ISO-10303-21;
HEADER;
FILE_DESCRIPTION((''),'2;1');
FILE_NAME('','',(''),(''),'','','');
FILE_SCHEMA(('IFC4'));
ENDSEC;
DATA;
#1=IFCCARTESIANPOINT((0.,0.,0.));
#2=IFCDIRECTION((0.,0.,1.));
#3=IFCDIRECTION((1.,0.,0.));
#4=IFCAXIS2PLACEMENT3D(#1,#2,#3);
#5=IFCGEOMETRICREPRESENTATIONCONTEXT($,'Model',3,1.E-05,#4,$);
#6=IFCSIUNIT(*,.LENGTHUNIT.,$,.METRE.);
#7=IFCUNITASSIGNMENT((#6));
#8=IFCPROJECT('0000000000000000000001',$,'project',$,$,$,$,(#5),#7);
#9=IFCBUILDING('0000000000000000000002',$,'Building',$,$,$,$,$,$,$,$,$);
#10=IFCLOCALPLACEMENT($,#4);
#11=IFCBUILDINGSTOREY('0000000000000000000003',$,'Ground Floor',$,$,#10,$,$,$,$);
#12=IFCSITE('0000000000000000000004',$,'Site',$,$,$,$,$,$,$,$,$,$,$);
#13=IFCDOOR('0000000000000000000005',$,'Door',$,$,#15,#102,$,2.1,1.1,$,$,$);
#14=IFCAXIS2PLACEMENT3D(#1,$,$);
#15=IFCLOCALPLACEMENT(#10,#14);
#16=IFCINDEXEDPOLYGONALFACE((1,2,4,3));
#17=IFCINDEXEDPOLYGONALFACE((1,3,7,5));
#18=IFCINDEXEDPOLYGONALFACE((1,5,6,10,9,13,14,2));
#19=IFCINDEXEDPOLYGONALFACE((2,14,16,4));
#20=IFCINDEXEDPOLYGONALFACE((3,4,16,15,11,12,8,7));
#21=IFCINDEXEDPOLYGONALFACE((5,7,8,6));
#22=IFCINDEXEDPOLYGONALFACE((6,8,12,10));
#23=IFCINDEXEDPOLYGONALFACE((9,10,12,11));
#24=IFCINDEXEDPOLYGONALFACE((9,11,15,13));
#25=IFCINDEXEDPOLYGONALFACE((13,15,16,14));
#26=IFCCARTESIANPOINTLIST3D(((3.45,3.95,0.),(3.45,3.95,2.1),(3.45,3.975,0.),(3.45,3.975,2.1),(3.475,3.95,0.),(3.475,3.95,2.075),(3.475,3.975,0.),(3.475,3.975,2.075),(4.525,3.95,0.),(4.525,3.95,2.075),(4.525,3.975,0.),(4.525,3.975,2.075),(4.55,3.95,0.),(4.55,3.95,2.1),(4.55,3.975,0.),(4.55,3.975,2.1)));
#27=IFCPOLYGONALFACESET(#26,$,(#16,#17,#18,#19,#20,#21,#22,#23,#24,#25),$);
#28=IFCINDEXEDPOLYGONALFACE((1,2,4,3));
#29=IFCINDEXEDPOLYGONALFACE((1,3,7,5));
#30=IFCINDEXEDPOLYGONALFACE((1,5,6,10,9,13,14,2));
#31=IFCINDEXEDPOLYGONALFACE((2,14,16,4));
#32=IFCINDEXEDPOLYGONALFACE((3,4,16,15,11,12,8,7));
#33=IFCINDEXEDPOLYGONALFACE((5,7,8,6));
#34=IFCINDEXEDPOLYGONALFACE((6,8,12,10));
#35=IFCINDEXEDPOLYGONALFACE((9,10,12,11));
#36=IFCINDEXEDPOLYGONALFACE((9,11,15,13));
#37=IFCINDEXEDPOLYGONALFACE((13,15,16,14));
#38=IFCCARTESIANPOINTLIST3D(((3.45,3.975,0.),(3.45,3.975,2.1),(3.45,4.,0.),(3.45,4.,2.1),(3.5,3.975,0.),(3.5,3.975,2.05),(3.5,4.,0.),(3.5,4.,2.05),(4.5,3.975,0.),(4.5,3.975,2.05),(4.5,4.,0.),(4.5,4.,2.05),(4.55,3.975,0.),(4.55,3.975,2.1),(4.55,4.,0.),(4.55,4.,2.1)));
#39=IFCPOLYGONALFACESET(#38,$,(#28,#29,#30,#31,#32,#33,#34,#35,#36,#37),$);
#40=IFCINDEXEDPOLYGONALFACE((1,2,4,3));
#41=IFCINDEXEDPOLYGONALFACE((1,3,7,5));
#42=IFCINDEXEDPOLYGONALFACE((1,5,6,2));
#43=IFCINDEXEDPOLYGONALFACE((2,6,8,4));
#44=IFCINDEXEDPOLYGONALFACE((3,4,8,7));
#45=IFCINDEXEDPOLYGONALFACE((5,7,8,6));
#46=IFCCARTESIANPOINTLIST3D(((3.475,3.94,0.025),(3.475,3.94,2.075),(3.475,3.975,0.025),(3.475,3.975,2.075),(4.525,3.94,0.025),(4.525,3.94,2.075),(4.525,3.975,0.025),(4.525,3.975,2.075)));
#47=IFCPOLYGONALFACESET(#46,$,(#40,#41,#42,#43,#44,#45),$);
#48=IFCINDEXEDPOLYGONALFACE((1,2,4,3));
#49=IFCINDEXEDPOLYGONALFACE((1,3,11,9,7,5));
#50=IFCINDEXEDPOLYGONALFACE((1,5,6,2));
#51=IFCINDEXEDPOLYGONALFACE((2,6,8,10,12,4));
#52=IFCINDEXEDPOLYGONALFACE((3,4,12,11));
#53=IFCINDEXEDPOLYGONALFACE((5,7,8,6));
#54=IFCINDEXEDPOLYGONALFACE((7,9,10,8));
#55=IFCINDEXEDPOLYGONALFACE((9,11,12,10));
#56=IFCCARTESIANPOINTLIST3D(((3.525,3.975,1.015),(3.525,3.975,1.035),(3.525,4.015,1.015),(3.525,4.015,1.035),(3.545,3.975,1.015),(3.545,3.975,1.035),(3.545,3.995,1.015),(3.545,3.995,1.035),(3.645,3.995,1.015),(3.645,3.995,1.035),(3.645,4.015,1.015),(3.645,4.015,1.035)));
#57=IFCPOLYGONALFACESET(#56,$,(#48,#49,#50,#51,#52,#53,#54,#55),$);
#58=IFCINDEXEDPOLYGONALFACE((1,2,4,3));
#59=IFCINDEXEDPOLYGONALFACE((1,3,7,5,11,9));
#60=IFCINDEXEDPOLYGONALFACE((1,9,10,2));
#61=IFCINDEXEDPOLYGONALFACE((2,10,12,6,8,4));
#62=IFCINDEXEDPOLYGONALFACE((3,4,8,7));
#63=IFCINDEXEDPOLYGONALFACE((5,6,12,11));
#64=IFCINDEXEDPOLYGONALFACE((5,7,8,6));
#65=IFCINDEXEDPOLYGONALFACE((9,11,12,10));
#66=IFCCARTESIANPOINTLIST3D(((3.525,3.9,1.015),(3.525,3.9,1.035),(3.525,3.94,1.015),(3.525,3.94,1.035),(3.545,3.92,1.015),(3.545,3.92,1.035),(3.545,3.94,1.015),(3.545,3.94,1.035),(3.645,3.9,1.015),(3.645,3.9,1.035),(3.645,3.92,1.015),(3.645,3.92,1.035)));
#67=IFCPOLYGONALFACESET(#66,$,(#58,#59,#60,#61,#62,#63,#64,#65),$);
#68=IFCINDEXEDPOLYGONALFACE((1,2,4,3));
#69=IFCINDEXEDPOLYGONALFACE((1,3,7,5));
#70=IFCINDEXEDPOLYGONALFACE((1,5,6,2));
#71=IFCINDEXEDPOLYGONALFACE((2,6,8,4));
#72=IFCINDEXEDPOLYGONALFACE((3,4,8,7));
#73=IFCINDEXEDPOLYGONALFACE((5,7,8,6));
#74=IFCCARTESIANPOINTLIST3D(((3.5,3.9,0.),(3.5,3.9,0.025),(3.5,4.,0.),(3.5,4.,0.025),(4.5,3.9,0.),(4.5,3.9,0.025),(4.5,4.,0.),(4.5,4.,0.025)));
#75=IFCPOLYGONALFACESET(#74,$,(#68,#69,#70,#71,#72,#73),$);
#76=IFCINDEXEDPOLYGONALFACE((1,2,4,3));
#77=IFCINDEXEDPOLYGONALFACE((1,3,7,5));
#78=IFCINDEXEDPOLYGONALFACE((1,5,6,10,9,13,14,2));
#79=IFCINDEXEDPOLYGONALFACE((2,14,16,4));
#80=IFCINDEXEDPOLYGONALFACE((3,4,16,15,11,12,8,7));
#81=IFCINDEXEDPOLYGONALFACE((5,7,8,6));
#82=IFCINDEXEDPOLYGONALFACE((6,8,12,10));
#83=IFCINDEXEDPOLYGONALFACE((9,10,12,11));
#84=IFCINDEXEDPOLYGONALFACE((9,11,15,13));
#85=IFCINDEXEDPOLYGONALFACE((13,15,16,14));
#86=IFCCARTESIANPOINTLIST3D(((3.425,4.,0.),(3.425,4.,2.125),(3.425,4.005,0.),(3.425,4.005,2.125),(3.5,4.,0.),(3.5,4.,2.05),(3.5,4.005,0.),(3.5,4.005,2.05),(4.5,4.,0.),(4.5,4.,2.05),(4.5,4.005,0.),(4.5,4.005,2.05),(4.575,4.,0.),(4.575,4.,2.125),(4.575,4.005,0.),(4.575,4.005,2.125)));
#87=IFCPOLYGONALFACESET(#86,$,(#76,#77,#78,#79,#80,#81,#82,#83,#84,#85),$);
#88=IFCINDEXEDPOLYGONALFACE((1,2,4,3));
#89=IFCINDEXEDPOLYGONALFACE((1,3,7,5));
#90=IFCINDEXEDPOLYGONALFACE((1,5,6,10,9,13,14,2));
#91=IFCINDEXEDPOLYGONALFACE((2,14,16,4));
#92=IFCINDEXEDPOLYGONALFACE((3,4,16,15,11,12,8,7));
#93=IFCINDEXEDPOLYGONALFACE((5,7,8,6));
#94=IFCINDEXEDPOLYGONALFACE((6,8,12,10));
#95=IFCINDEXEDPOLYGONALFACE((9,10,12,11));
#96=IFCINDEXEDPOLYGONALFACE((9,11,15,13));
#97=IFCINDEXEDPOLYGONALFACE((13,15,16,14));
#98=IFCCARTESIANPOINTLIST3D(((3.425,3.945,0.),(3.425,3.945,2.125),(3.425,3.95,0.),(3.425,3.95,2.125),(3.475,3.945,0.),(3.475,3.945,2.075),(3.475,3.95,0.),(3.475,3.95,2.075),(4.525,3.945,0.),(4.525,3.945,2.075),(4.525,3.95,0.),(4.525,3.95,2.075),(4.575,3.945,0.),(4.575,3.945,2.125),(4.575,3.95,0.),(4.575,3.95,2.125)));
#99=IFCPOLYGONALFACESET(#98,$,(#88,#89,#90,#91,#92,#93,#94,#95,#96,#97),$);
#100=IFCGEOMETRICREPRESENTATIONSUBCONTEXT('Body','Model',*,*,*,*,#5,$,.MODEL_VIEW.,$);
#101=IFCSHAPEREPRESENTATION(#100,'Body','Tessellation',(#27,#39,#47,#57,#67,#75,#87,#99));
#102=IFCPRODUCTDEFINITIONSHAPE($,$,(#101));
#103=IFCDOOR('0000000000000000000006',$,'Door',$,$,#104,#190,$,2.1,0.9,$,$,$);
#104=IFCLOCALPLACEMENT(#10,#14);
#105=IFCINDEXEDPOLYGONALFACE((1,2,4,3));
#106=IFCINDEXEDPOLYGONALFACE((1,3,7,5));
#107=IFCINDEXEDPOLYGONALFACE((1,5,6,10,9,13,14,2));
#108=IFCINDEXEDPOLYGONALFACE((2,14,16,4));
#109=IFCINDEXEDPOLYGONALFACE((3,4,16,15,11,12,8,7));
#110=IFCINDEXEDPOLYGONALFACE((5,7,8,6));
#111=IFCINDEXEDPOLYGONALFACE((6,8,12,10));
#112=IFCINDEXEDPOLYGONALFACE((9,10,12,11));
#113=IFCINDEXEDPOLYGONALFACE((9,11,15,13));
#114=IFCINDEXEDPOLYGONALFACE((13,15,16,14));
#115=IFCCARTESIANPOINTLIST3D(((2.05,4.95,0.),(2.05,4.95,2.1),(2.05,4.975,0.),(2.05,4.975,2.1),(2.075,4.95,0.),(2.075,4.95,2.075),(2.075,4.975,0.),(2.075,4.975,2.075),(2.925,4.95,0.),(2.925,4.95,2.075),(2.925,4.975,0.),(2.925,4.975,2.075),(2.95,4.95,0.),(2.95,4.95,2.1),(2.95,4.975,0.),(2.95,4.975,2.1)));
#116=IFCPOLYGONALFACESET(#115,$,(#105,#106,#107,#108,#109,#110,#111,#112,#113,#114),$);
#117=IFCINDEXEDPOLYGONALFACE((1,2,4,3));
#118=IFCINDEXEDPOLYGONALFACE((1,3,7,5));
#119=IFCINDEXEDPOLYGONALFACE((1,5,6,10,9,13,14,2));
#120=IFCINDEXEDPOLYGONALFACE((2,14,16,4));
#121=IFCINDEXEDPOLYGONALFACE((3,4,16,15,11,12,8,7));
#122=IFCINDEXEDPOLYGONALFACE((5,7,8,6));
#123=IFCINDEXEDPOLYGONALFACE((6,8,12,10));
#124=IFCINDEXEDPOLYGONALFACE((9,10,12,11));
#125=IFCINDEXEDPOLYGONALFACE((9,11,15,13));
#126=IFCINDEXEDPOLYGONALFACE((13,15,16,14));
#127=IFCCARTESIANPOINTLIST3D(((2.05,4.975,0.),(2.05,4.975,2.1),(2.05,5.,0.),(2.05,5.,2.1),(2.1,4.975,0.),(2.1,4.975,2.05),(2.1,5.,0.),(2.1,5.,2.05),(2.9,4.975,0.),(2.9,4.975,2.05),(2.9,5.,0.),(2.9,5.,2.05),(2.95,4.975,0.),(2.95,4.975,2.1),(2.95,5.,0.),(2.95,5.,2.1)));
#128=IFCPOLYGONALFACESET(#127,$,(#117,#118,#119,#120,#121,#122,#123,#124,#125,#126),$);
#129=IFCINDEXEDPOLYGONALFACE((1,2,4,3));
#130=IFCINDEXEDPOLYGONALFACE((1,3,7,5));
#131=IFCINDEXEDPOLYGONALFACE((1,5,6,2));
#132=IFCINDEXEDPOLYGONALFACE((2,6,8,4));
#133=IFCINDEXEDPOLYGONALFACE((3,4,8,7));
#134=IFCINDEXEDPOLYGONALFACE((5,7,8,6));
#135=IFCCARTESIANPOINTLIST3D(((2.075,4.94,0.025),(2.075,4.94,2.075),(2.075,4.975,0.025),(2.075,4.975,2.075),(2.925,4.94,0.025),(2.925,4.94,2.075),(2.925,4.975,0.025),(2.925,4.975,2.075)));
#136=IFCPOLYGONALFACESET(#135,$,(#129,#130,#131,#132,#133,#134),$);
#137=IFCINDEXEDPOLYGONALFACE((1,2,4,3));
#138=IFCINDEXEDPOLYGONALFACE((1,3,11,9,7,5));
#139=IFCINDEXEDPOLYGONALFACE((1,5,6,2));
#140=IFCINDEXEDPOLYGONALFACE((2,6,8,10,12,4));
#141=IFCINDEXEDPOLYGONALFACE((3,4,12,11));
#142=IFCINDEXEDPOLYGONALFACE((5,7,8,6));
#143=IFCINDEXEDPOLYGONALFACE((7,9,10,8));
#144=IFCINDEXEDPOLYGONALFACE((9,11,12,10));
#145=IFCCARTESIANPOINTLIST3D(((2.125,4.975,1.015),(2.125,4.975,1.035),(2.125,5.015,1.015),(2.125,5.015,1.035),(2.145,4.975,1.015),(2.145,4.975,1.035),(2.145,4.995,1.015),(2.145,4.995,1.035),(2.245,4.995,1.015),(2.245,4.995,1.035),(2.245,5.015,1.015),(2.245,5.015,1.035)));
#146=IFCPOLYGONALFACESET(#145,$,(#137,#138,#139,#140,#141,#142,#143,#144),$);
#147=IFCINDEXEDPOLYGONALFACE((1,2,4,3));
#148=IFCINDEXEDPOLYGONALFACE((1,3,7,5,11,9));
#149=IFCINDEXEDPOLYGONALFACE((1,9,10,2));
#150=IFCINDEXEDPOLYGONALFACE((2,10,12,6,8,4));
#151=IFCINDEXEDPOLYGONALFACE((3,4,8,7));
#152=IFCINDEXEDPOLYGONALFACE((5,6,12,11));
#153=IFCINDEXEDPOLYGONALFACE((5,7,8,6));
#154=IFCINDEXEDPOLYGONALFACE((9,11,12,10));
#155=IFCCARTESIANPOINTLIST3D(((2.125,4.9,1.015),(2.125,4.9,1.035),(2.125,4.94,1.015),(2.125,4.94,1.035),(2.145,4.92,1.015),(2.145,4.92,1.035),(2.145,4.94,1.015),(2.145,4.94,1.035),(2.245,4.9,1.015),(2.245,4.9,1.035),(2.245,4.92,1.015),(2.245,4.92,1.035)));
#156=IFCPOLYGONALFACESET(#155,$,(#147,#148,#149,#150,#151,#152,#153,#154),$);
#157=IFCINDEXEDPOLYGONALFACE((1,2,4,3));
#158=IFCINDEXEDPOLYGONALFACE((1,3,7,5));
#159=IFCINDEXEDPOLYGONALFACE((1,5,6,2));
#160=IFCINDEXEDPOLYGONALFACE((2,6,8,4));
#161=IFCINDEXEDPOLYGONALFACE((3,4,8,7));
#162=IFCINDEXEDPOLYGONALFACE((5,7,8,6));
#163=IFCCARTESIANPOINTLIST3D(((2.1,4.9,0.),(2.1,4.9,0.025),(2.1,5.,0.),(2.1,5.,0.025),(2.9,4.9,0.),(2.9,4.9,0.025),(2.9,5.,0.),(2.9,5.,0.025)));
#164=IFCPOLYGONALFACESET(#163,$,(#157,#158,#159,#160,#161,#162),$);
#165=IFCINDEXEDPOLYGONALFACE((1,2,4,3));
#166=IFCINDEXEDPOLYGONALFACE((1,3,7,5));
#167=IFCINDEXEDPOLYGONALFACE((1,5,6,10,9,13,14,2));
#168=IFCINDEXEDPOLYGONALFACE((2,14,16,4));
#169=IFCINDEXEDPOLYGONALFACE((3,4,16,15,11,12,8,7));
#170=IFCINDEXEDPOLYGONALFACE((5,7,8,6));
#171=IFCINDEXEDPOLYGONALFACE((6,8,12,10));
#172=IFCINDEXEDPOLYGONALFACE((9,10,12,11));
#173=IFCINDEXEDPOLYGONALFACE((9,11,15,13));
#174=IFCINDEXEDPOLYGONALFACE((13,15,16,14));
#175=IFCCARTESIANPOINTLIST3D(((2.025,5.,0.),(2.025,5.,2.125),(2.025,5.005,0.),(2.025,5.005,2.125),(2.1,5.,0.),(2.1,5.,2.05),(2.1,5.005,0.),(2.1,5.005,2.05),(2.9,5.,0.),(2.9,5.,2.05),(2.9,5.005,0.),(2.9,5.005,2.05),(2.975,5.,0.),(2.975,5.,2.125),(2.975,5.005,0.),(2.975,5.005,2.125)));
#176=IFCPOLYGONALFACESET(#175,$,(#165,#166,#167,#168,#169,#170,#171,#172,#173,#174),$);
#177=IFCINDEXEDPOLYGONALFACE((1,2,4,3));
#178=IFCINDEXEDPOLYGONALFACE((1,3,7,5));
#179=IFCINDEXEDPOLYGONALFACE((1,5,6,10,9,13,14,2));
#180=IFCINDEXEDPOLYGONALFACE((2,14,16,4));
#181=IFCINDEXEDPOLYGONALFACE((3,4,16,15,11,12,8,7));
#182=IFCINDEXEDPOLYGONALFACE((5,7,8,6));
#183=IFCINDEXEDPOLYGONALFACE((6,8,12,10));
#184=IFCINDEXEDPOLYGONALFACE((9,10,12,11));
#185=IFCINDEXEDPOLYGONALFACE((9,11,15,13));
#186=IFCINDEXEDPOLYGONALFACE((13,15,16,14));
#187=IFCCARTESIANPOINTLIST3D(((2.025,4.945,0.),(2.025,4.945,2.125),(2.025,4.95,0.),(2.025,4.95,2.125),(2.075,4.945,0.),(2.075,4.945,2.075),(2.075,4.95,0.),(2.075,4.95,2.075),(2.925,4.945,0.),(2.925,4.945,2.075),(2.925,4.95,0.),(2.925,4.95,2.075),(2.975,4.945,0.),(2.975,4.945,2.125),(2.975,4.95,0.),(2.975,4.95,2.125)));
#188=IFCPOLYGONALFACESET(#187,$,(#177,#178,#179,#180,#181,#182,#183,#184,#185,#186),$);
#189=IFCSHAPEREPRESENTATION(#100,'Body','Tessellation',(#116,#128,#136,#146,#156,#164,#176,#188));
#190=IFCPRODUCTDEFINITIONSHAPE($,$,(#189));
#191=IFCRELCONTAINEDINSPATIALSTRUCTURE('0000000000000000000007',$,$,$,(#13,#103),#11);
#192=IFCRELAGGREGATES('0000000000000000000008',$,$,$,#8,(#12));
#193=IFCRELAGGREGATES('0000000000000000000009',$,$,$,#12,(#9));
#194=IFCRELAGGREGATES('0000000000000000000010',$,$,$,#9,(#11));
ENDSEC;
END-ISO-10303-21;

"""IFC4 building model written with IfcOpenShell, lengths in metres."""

from ifc_helpers import new_model, si_unit, frame, origin_with_axes, place, context, subcontext, project, spatial, line, indexed_curve, outline, extrude, element, save


model = new_model("IFC4")

# Units and contexts
model_context = context("Model", 3, precision=1e-05, world=origin_with_axes())
body_context = subcontext(model_context, "Body", "Model", "MODEL_VIEW")
ifc_project = project(units=[si_unit("LENGTHUNIT", "METRE")], contexts=[model_context])

# Site, building, storey
site = spatial("IfcSite", under=ifc_project, Name="Site")
building = spatial("IfcBuilding", under=site, Name="Building")
storey_placement = place(None, origin_with_axes())
storey = spatial("IfcBuildingStorey", under=building, at=storey_placement, Name="Ground Floor")

# Doors
door_1_placement = place(storey_placement, frame((4.55, 4.0, 0.0), z_axis=(0.0, 0.0, 1.0), x_axis=(-1.0, 0.0, 0.0)))
element("IfcDoor", 1, at=door_1_placement, inside=storey, Name="Door", OverallHeight=2.1, OverallWidth=1.1, context=body_context, shape_type="SweptSolid", body=[
    extrude(outline(indexed_curve([(0.0, 0.0), (0.0, 2.1), (1.1, 2.1), (1.1, 0.0), (1.075, 0.0), (1.075, 2.075), (0.025, 2.075), (0.025, 0.0)], segments=[line(1, 2, 3, 4, 5, 6, 7, 8, 1)])), frame((0.0, 0.025, 0.0), z_axis=(0.0, -1.0, 0.0), x_axis=(1.0, 0.0, 0.0)), (0.0, 0.0, -1.0), 0.025),
    extrude(outline(indexed_curve([(0.0, 0.0), (0.0, 2.1), (1.1, 2.1), (1.1, 0.0), (1.05, 0.0), (1.05, 2.05), (0.05, 2.05), (0.05, 0.0)], segments=[line(1, 2, 3, 4, 5, 6, 7, 8, 1)])), frame((0.0, 0.0, 0.0), z_axis=(0.0, -1.0, 0.0), x_axis=(1.0, 0.0, 0.0)), (0.0, 0.0, -1.0), 0.025),
    extrude(outline(indexed_curve([(0.0, 0.0), (1.05, 0.0), (1.05, 0.035), (0.0, 0.035)], segments=[line(1, 2, 3, 4, 1)])), frame((0.025, 0.025, 0.025), z_axis=(0.0, 0.0, 1.0), x_axis=(1.0, 0.0, 0.0)), (0.0, 0.0, 1.0), 2.05),
    extrude(outline(indexed_curve([(0.0, 0.0), (0.0, -0.04), (-0.12, -0.04), (-0.12, -0.02), (-0.02, -0.02), (-0.02, 0.0)], segments=[line(1, 2, 3, 4, 5, 6, 1)])), frame((1.025, 0.025, 1.015), z_axis=(0.0, 0.0, 1.0), x_axis=(1.0, 0.0, 0.0)), (0.0, 0.0, 1.0), 0.02),
    extrude(outline(indexed_curve([(0.0, 0.0), (0.0, 0.04), (-0.12, 0.04), (-0.12, 0.02), (-0.02, 0.02), (-0.02, 0.0)], segments=[line(1, 2, 3, 4, 5, 6, 1)])), frame((1.025, 0.06, 1.015), z_axis=(0.0, 0.0, 1.0), x_axis=(1.0, 0.0, 0.0)), (0.0, 0.0, 1.0), 0.02),
    extrude(outline(indexed_curve([(0.0, 0.0), (1.0, 0.0), (1.0, 0.1), (0.0, 0.1)], segments=[line(1, 2, 3, 4, 1)])), frame((0.05, 0.0, 0.0), z_axis=(0.0, 0.0, 1.0), x_axis=(1.0, 0.0, 0.0)), (0.0, 0.0, 1.0), 0.025),
    extrude(outline(indexed_curve([(0.0, 0.0), (0.0, 2.125), (1.15, 2.125), (1.15, 0.0), (1.075, 0.0), (1.075, 2.05), (0.075, 2.05), (0.075, 0.0)], segments=[line(1, 2, 3, 4, 5, 6, 7, 8, 1)])), frame((-0.025, -0.005, 0.0), z_axis=(0.0, -1.0, 0.0), x_axis=(1.0, 0.0, 0.0)), (0.0, 0.0, -1.0), 0.005),
    extrude(outline(indexed_curve([(0.0, 0.0), (0.0, 2.125), (1.15, 2.125), (1.15, 0.0), (1.1, 0.0), (1.1, 2.075), (0.05, 2.075), (0.05, 0.0)], segments=[line(1, 2, 3, 4, 5, 6, 7, 8, 1)])), frame((-0.025, 0.05, 0.0), z_axis=(0.0, -1.0, 0.0), x_axis=(1.0, 0.0, 0.0)), (0.0, 0.0, -1.0), 0.005),
])
door_2_placement = place(storey_placement, frame((2.95, 5.0, 0.0), z_axis=(0.0, 0.0, 1.0), x_axis=(-1.0, 0.0, 0.0)))
element("IfcDoor", 2, at=door_2_placement, inside=storey, Name="Door", OverallHeight=2.1, OverallWidth=0.9, context=body_context, shape_type="SweptSolid", body=[
    extrude(outline(indexed_curve([(0.0, 0.0), (0.0, 2.1), (0.9, 2.1), (0.9, 0.0), (0.875, 0.0), (0.875, 2.075), (0.025, 2.075), (0.025, 0.0)], segments=[line(1, 2, 3, 4, 5, 6, 7, 8, 1)])), frame((0.0, 0.025, 0.0), z_axis=(0.0, -1.0, 0.0), x_axis=(1.0, 0.0, 0.0)), (0.0, 0.0, -1.0), 0.025),
    extrude(outline(indexed_curve([(0.0, 0.0), (0.0, 2.1), (0.9, 2.1), (0.9, 0.0), (0.85, 0.0), (0.85, 2.05), (0.05, 2.05), (0.05, 0.0)], segments=[line(1, 2, 3, 4, 5, 6, 7, 8, 1)])), frame((0.0, 0.0, 0.0), z_axis=(0.0, -1.0, 0.0), x_axis=(1.0, 0.0, 0.0)), (0.0, 0.0, -1.0), 0.025),
    extrude(outline(indexed_curve([(0.0, 0.0), (0.85, 0.0), (0.85, 0.035), (0.0, 0.035)], segments=[line(1, 2, 3, 4, 1)])), frame((0.025, 0.025, 0.025), z_axis=(0.0, 0.0, 1.0), x_axis=(1.0, 0.0, 0.0)), (0.0, 0.0, 1.0), 2.05),
    extrude(outline(indexed_curve([(0.0, 0.0), (0.0, -0.04), (-0.12, -0.04), (-0.12, -0.02), (-0.02, -0.02), (-0.02, 0.0)], segments=[line(1, 2, 3, 4, 5, 6, 1)])), frame((0.825, 0.025, 1.015), z_axis=(0.0, 0.0, 1.0), x_axis=(1.0, 0.0, 0.0)), (0.0, 0.0, 1.0), 0.02),
    extrude(outline(indexed_curve([(0.0, 0.0), (0.0, 0.04), (-0.12, 0.04), (-0.12, 0.02), (-0.02, 0.02), (-0.02, 0.0)], segments=[line(1, 2, 3, 4, 5, 6, 1)])), frame((0.825, 0.06, 1.015), z_axis=(0.0, 0.0, 1.0), x_axis=(1.0, 0.0, 0.0)), (0.0, 0.0, 1.0), 0.02),
    extrude(outline(indexed_curve([(0.0, 0.0), (0.8, 0.0), (0.8, 0.1), (0.0, 0.1)], segments=[line(1, 2, 3, 4, 1)])), frame((0.05, 0.0, 0.0), z_axis=(0.0, 0.0, 1.0), x_axis=(1.0, 0.0, 0.0)), (0.0, 0.0, 1.0), 0.025),
    extrude(outline(indexed_curve([(0.0, 0.0), (0.0, 2.125), (0.95, 2.125), (0.95, 0.0), (0.875, 0.0), (0.875, 2.05), (0.075, 2.05), (0.075, 0.0)], segments=[line(1, 2, 3, 4, 5, 6, 7, 8, 1)])), frame((-0.025, -0.005, 0.0), z_axis=(0.0, -1.0, 0.0), x_axis=(1.0, 0.0, 0.0)), (0.0, 0.0, -1.0), 0.005),
    extrude(outline(indexed_curve([(0.0, 0.0), (0.0, 2.125), (0.95, 2.125), (0.95, 0.0), (0.9, 0.0), (0.9, 2.075), (0.05, 2.075), (0.05, 0.0)], segments=[line(1, 2, 3, 4, 5, 6, 7, 8, 1)])), frame((-0.025, 0.05, 0.0), z_axis=(0.0, -1.0, 0.0), x_axis=(1.0, 0.0, 0.0)), (0.0, 0.0, -1.0), 0.005),
])

save(model, "model.ifc")
